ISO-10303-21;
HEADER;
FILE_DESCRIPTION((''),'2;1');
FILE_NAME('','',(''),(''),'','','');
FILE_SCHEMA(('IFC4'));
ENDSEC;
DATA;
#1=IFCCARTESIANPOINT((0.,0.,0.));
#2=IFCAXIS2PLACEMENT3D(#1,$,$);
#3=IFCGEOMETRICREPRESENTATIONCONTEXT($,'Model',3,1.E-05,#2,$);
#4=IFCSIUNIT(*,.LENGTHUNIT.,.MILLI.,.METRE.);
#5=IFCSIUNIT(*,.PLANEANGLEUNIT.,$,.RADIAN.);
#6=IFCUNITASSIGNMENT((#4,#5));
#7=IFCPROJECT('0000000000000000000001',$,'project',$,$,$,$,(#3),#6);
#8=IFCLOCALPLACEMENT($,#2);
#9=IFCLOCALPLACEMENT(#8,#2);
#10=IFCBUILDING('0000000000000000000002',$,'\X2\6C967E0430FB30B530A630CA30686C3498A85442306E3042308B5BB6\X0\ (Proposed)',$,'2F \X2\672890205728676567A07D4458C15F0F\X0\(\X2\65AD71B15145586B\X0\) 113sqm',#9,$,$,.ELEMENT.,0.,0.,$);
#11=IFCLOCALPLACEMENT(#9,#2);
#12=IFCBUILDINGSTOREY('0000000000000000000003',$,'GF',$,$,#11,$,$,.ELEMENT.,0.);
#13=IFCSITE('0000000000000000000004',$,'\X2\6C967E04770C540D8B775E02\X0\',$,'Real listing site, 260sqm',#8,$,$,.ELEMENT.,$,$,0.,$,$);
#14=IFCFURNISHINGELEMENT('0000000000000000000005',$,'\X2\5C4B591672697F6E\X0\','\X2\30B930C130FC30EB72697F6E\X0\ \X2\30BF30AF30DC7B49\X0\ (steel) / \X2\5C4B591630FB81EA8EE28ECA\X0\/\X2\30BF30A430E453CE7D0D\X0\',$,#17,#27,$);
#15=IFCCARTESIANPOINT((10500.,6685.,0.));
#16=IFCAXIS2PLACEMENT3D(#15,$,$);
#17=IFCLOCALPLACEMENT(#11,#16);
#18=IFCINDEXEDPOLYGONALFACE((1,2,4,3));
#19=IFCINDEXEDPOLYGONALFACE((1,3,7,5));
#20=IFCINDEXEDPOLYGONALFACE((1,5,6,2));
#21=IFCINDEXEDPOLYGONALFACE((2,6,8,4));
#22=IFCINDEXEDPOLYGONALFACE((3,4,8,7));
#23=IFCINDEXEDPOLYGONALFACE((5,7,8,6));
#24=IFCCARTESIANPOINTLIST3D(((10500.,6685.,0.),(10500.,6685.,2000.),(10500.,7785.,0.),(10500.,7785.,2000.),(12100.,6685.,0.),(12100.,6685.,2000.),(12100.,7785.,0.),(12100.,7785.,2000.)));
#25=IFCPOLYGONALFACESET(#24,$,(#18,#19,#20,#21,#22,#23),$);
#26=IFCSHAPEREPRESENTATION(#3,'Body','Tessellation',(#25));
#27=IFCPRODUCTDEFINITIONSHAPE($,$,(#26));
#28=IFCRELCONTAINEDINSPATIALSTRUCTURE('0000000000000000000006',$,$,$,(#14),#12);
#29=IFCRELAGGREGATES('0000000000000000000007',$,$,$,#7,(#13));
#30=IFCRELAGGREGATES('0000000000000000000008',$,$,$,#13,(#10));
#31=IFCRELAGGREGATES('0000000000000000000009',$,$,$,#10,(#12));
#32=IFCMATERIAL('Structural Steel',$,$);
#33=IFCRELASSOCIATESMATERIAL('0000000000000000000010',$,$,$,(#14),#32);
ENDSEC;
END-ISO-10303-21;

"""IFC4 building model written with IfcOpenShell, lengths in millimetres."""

from ifc_helpers import new_model, si_unit, frame, frame_2d, origin, place, context, project, spatial, rectangle, extrude, material, element, save


model = new_model("IFC4")

# Units and contexts
model_context = context("Model", 3, precision=1e-05, world=origin())
ifc_project = project(units=[si_unit("LENGTHUNIT", "METRE", prefix="MILLI"), si_unit("PLANEANGLEUNIT", "RADIAN")], contexts=[model_context])

# Site, building, storey
site_placement = place(None, origin())
site = spatial("IfcSite", under=ifc_project, at=site_placement, Name="沖縄県名護市", ObjectType="Real listing site, 260sqm", CompositionType="ELEMENT", RefElevation=0.0)
building_placement = place(site_placement, origin())
building = spatial("IfcBuilding", under=site, at=building_placement, Name="沖縄・サウナと水風呂のある家 (Proposed)", ObjectType="2F 木造在来枠組壁式(断熱充填) 113sqm", CompositionType="ELEMENT", ElevationOfRefHeight=0.0, ElevationOfTerrain=0.0)
storey_placement = place(building_placement, origin())
storey = spatial("IfcBuildingStorey", under=building, at=storey_placement, Name="GF", CompositionType="ELEMENT", Elevation=0.0)

# Shared definitions
ifc_material_1 = material(Name="Structural Steel")

# Furnishing element
furnishing_placement = place(storey_placement, frame((10500.0, 6685.0, 0.0)))
element("IfcFurnishingElement", 1, at=furnishing_placement, inside=storey, material=ifc_material_1, Name="屋外物置", Description="スチール物置 タクボ等 (steel) / 屋外・自転車/タイヤ収納", context=model_context, shape_type="SweptSolid", body=[
    extrude(rectangle(XDim=1600.0, YDim=1100.0, at=frame_2d((800.0, 550.0))), frame((10500.0, 6685.0, 0.0)), (0.0, 0.0, 1.0), 2000.0),
])

save(model, "model.ifc")
